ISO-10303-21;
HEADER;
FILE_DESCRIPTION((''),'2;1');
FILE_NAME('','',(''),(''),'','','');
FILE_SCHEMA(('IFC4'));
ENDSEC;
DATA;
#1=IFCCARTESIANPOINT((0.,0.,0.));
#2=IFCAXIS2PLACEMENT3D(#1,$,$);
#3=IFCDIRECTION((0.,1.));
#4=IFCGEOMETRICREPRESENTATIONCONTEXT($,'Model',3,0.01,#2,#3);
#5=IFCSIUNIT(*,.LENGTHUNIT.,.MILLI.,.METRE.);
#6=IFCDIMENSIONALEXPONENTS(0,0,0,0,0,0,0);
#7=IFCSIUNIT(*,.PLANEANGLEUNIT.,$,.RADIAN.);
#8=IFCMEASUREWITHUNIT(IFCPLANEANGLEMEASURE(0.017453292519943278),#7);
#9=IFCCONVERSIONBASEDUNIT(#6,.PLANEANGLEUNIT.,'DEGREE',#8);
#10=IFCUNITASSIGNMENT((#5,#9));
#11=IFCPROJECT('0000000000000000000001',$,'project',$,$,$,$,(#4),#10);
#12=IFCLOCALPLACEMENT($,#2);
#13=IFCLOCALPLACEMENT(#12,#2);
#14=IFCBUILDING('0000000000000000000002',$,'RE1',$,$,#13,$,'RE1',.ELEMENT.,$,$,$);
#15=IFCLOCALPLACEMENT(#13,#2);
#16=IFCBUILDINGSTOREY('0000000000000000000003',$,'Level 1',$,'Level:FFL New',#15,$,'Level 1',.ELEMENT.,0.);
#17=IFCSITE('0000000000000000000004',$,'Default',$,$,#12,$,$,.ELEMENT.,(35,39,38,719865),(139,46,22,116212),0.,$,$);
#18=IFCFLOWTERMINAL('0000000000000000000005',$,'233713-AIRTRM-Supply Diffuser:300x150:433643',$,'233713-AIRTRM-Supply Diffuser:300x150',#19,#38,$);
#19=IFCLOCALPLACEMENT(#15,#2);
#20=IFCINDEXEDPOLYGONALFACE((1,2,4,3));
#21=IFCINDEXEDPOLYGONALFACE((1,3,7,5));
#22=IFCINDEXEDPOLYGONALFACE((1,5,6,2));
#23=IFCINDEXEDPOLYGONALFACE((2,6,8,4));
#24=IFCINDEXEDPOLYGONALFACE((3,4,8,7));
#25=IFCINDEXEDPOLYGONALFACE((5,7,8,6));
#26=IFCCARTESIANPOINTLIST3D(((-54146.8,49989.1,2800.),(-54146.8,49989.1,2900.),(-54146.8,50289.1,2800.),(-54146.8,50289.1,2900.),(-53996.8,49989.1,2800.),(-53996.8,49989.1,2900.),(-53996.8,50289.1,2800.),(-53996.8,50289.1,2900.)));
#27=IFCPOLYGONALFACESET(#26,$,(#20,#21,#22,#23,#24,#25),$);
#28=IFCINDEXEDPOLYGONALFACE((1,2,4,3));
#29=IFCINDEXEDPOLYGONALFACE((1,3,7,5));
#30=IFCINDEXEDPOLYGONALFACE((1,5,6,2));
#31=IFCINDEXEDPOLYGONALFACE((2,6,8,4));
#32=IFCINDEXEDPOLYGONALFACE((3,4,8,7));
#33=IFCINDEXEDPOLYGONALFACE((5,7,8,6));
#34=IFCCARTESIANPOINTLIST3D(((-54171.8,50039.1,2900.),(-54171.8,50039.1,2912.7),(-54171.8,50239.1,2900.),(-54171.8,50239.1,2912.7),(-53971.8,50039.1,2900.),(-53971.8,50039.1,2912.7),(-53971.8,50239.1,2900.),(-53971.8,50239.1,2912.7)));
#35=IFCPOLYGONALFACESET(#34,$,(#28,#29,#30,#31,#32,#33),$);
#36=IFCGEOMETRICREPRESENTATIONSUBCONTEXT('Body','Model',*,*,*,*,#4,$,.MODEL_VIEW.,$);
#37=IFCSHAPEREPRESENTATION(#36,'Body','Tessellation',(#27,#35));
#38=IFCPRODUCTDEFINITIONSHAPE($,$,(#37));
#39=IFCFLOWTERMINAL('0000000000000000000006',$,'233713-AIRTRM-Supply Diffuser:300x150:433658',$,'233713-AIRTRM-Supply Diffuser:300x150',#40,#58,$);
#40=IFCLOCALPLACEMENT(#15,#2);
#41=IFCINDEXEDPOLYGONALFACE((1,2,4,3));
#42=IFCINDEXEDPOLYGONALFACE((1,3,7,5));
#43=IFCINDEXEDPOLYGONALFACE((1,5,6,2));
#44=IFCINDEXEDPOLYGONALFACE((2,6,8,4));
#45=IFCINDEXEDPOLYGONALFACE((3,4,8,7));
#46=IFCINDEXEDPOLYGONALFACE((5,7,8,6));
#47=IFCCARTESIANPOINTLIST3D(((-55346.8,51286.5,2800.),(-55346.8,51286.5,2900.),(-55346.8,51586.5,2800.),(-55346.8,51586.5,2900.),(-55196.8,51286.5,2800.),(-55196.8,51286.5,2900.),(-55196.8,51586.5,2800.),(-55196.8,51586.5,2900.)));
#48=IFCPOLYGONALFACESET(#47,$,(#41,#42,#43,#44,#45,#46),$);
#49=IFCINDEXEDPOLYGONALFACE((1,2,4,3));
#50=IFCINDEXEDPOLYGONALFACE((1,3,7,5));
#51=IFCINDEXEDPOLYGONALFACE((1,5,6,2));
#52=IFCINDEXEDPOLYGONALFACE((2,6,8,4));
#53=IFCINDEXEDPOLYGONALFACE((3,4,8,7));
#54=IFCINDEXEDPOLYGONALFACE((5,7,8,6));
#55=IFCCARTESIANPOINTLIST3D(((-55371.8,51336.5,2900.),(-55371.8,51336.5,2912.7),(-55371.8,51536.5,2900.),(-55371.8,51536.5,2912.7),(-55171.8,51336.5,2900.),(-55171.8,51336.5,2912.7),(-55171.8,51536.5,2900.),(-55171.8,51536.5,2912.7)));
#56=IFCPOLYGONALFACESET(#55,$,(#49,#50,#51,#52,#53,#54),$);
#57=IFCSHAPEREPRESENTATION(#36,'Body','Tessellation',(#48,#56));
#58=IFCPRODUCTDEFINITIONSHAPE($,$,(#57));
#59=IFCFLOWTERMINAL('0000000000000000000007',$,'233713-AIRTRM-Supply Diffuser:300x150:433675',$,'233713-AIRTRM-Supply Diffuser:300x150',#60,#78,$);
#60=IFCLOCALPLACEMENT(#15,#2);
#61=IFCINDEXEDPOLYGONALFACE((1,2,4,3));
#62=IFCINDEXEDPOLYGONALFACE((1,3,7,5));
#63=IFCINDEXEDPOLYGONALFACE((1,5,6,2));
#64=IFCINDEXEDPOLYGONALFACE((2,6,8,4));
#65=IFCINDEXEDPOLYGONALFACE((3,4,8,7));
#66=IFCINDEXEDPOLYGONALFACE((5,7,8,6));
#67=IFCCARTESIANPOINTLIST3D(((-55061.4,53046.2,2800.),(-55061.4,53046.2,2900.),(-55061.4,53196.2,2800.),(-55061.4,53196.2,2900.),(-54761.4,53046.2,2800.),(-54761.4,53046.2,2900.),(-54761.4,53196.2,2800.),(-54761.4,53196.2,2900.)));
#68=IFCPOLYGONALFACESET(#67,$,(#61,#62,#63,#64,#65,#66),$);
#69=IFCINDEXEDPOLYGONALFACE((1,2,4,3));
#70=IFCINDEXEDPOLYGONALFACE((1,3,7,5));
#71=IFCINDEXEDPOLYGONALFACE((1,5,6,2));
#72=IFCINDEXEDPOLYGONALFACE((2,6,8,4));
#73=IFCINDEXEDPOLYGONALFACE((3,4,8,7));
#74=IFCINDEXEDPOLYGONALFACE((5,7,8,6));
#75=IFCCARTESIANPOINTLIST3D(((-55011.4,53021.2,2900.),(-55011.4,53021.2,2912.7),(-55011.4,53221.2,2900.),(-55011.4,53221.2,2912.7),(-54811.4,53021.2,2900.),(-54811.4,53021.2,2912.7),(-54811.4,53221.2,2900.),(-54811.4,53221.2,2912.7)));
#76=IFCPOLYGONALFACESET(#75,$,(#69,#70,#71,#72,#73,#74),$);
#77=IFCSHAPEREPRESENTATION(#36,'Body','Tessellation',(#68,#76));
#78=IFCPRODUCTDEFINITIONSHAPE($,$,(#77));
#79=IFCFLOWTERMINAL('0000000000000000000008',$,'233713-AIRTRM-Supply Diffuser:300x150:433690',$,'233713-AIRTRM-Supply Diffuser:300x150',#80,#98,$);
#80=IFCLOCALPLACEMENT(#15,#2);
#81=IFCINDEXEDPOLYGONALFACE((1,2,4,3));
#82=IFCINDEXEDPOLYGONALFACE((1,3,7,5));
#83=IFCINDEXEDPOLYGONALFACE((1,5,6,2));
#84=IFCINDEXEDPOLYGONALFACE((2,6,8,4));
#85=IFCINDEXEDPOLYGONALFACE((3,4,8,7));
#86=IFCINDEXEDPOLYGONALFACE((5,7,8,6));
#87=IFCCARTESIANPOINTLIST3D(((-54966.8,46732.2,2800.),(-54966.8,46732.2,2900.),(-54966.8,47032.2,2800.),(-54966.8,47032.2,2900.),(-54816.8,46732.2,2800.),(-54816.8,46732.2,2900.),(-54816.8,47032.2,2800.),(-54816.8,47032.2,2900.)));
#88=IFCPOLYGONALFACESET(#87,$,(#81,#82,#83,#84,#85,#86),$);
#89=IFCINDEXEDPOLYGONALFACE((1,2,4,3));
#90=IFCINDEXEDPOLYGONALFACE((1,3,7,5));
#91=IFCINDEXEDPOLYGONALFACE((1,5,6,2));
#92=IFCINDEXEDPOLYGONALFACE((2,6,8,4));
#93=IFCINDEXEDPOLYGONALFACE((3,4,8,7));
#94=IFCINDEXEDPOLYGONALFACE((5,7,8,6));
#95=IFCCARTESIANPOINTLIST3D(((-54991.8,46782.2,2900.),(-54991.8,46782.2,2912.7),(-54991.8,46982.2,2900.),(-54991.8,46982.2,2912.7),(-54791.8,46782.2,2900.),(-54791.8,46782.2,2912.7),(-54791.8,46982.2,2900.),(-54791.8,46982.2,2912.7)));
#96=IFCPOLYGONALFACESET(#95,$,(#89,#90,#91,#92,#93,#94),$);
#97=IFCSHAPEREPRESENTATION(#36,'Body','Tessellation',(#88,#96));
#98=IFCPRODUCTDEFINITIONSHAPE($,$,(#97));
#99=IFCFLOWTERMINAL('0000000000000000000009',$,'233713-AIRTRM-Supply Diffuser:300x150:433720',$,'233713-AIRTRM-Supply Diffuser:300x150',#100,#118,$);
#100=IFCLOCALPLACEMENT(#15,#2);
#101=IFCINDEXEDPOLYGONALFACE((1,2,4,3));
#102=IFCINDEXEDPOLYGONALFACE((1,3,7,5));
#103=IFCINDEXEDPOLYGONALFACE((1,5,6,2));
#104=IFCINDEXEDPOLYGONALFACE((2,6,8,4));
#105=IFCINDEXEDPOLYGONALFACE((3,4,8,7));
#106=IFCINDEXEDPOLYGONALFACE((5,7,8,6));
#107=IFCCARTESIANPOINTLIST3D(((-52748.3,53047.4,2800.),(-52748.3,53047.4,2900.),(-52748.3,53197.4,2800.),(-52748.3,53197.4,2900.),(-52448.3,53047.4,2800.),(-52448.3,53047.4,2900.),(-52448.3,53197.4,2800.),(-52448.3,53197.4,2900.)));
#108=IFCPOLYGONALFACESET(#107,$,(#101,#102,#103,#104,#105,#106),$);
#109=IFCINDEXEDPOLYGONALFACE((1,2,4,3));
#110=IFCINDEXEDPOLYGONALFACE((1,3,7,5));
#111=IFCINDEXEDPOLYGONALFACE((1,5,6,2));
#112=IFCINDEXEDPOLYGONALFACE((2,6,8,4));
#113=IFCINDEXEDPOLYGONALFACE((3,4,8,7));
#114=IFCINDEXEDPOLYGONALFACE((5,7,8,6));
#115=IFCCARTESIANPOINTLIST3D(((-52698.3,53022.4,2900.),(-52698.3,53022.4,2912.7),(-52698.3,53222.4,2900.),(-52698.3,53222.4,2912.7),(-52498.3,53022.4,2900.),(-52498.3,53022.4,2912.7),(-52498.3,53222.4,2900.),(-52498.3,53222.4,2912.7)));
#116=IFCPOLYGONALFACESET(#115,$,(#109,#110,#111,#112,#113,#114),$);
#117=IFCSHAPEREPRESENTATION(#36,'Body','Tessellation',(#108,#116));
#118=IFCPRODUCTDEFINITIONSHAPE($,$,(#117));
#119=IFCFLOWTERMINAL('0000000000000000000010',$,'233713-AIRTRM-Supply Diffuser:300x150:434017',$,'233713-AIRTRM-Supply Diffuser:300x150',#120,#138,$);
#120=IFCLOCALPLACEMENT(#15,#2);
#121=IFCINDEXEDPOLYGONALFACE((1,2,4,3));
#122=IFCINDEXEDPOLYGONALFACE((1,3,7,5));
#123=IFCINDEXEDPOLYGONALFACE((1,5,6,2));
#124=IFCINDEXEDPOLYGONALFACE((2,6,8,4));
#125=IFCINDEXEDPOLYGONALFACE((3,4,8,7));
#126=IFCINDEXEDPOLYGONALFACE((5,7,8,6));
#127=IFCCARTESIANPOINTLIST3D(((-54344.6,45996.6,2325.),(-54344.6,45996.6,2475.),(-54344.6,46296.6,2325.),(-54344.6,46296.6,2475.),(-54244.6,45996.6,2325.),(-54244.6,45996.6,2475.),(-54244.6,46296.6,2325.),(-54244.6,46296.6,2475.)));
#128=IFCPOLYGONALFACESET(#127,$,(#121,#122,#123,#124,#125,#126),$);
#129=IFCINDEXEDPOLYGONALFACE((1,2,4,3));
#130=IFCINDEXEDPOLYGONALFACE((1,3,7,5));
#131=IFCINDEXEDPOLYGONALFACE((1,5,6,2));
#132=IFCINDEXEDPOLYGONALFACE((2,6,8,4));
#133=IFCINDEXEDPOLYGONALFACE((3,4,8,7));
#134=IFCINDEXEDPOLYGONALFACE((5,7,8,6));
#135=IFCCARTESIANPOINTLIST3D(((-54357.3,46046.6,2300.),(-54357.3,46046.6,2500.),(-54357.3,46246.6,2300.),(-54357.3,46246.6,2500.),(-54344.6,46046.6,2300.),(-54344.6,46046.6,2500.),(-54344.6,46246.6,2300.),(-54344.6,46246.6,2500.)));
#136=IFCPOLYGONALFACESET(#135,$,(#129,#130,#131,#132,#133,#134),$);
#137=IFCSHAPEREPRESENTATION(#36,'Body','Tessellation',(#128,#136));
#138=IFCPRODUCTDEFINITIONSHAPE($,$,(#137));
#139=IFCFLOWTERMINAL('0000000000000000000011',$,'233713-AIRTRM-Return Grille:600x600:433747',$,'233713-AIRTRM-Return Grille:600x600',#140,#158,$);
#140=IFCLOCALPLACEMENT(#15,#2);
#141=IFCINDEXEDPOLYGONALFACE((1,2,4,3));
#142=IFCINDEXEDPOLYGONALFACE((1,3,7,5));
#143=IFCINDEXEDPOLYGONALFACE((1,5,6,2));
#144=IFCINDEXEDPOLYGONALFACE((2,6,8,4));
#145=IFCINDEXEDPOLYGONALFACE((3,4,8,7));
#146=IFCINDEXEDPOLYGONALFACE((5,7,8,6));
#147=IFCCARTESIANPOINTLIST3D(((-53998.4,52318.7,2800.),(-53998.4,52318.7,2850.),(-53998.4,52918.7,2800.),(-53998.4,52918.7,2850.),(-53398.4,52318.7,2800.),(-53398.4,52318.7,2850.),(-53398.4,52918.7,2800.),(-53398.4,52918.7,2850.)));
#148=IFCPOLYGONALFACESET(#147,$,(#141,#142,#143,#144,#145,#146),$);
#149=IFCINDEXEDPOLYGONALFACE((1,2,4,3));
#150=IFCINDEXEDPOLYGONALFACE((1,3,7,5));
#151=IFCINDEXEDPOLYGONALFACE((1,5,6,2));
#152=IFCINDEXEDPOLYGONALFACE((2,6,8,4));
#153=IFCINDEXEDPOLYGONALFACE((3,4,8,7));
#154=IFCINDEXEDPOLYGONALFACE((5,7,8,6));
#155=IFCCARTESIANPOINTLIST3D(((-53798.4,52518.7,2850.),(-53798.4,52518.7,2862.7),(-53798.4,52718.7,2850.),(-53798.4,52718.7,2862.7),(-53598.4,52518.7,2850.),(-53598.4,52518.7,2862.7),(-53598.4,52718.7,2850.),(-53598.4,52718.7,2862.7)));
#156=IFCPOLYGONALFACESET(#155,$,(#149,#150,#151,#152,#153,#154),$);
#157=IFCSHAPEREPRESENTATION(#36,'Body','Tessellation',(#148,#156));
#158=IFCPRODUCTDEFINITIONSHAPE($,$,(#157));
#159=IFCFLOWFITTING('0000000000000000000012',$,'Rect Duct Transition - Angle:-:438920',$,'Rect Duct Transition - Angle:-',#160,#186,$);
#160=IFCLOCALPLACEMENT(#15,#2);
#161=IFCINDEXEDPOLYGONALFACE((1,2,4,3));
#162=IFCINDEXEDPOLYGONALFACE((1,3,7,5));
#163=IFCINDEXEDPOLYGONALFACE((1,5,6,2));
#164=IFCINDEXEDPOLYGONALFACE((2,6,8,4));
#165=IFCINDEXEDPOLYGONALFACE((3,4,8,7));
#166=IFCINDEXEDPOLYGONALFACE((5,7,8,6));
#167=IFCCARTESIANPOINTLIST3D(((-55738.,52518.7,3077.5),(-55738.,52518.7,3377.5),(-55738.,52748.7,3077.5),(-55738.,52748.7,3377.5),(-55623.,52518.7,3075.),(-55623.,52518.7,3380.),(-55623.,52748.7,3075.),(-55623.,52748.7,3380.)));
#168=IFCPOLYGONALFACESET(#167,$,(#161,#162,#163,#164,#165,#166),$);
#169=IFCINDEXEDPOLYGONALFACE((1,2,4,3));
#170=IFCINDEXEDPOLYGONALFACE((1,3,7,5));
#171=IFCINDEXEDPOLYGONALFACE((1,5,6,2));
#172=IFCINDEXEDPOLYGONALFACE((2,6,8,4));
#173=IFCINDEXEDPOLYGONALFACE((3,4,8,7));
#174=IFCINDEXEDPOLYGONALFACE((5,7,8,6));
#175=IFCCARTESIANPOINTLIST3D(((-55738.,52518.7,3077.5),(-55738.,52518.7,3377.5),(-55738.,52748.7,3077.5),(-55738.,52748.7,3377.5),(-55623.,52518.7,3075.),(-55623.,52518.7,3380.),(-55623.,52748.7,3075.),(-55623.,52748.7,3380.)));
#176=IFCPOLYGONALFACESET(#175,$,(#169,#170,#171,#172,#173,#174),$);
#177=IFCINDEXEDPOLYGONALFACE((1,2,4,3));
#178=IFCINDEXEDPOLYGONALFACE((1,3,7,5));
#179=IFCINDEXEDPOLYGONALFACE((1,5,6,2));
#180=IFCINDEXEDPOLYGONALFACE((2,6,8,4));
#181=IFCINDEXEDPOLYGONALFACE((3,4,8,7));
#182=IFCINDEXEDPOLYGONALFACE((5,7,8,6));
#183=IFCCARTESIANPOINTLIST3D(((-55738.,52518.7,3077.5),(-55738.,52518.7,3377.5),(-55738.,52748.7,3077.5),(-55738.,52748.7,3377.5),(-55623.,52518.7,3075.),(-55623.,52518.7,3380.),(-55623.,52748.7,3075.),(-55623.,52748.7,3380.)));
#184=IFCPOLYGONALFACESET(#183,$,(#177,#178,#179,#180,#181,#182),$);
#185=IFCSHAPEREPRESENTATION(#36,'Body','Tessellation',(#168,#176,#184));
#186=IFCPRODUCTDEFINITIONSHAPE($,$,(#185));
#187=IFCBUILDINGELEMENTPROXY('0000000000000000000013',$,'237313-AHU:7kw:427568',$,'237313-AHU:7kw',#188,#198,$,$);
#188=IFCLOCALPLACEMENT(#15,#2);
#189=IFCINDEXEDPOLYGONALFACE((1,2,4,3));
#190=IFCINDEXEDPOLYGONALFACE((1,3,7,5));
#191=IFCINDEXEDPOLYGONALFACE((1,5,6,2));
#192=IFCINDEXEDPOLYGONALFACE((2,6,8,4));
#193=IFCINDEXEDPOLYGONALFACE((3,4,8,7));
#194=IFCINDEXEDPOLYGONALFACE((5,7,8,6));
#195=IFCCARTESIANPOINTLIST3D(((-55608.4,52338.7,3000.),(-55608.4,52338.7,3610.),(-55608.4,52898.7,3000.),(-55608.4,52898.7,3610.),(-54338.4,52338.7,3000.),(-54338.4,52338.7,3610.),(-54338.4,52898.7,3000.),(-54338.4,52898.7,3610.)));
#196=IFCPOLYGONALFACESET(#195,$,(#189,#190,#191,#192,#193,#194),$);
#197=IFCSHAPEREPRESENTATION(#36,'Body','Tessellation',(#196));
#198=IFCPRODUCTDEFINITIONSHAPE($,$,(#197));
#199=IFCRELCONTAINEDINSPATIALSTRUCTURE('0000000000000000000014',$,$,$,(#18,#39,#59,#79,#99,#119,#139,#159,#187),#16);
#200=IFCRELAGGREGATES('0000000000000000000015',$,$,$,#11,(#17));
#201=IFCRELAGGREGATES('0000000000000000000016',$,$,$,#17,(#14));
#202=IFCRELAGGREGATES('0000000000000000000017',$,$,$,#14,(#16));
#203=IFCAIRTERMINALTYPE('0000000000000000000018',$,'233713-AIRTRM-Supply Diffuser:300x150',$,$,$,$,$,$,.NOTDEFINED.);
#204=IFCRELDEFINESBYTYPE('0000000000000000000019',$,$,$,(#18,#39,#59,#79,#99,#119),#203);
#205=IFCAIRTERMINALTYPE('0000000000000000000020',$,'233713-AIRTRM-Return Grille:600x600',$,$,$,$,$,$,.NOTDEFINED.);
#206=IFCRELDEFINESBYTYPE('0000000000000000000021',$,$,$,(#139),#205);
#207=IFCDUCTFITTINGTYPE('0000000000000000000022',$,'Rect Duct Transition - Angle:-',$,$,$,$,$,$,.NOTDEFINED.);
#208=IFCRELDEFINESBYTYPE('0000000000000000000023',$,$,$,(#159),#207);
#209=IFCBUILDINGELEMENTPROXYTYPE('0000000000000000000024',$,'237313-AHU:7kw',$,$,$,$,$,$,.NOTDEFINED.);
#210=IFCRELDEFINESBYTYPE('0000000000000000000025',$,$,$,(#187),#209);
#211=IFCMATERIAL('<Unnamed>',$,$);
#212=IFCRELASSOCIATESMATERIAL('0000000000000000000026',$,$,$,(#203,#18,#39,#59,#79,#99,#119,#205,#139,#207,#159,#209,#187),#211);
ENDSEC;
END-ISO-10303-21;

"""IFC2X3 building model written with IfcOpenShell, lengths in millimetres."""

from ifc_helpers import new_model, entity, si_unit, converted_unit, direction, frame, frame_2d, origin, origin_2d_with_axis, place, context, subcontext, project, spatial, polyline, rectangle, outline, extrude, source, transform, mapped, material, type_object, type_shapes, element, save


model = new_model("IFC2X3")

# Units and contexts
model_context = context("Model", 3, precision=0.01, world=origin(), true_north=direction((0.0, 1.0)))
body_context = subcontext(model_context, "Body", "Model", "MODEL_VIEW")
ifc_project = project(units=[si_unit("LENGTHUNIT", "METRE", prefix="MILLI"), converted_unit("PLANEANGLEUNIT", "DEGREE", entity("IfcPlaneAngleMeasure", 0.017453292519943278), si_unit("PLANEANGLEUNIT", "RADIAN"), dimensions=[0, 0, 0, 0, 0, 0, 0])], contexts=[model_context])

# Site, building, storey
site_placement = place(None, origin())
site = spatial("IfcSite", under=ifc_project, at=site_placement, Name="Default", CompositionType="ELEMENT", RefLatitude=(35, 39, 38, 719865), RefLongitude=(139, 46, 22, 116212), RefElevation=0.0)
building_placement = place(site_placement, origin())
building = spatial("IfcBuilding", under=site, at=building_placement, Name="RE1", LongName="RE1", CompositionType="ELEMENT")
storey_placement = place(building_placement, origin())
storey = spatial("IfcBuildingStorey", under=building, at=storey_placement, Name="Level 1", ObjectType="Level:FFL New", LongName="Level 1", CompositionType="ELEMENT", Elevation=0.0)

# Flow terminals
ifc_material = material(Name="<Unnamed>")
air_terminal_type_1 = type_object("IfcAirTerminalType", Name="233713-AIRTRM-Supply Diffuser:300x150", PredefinedType="NOTDEFINED", material=ifc_material)
shared_shape_1 = source(origin(), body_context, "Body", "SweptSolid", [
    extrude(rectangle(XDim=300.0, YDim=150.0, at=origin_2d_with_axis()), frame((0.0, 0.0, -100.0), z_axis=(0.0, 0.0, 1.0), x_axis=(-1.0, 0.0, 0.0)), (0.0, 0.0, 1.0), 100.0),
    extrude(rectangle(XDim=200.0, YDim=200.0, at=frame_2d((0.0, 0.0), x_axis=(1.0, 0.0))), frame((0.0, 0.0, -112.7), z_axis=(0.0, 0.0, 1.0), x_axis=(-1.0, 0.0, 0.0)), (0.0, 0.0, 1.0), 12.7),
])
type_shapes(air_terminal_type_1, [shared_shape_1])
for number, where, z_axis, x_axis, name in (
    (1, (-54071.8, 50139.1, 2800.0), (0.0, 0.0, -1.0), (0.0, 1.0, 0.0), "233713-AIRTRM-Supply Diffuser:300x150:433643"),
    (2, (-55271.8, 51436.5, 2800.0), (0.0, 0.0, -1.0), (0.0, 1.0, 0.0), "233713-AIRTRM-Supply Diffuser:300x150:433658"),
    (3, (-54911.4, 53121.2, 2800.0), (0.0, 0.0, -1.0), (-1.0, 0.0, 0.0), "233713-AIRTRM-Supply Diffuser:300x150:433675"),
    (4, (-54891.8, 46882.2, 2800.0), (0.0, 0.0, -1.0), (0.0, 1.0, 0.0), "233713-AIRTRM-Supply Diffuser:300x150:433690"),
    (5, (-52598.3, 53122.4, 2800.0), (0.0, 0.0, -1.0), (1.0, 0.0, 0.0), "233713-AIRTRM-Supply Diffuser:300x150:433720"),
    (6, (-54244.6, 46146.6, 2400.0), (1.0, 0.0, 0.0), (0.0, 1.0, 0.0), "233713-AIRTRM-Supply Diffuser:300x150:434017"),
):
    element("IfcFlowTerminal", number, at=place(storey_placement, frame(where, z_axis=z_axis, x_axis=x_axis)), inside=storey, type_object=air_terminal_type_1, material=ifc_material, Name=name, ObjectType="233713-AIRTRM-Supply Diffuser:300x150", context=body_context, shape_type="MappedRepresentation", body=[
        mapped(shared_shape_1, transform((0.0, 0.0, 0.0), scale=1.0)),
    ])
air_terminal_type_2 = type_object("IfcAirTerminalType", Name="233713-AIRTRM-Return Grille:600x600", PredefinedType="NOTDEFINED", material=ifc_material)
shared_shape_2 = source(origin(), body_context, "Body", "SweptSolid", [
    extrude(rectangle(XDim=600.0, YDim=600.0, at=frame_2d((0.0, 0.0), x_axis=(1.0, 0.0))), frame((0.0, 0.0, -50.0), z_axis=(0.0, 0.0, 1.0), x_axis=(-1.0, 0.0, 0.0)), (0.0, 0.0, 1.0), 50.0),
    extrude(rectangle(XDim=200.0, YDim=200.0, at=frame_2d((0.0, 0.0), x_axis=(1.0, 0.0))), frame((0.0, 0.0, -62.7), z_axis=(0.0, 0.0, 1.0), x_axis=(-1.0, 0.0, 0.0)), (0.0, 0.0, 1.0), 12.7),
])
type_shapes(air_terminal_type_2, [shared_shape_2])
flow_terminal_placement = place(storey_placement, frame((-53698.4, 52618.7, 2800.0), z_axis=(0.0, 0.0, -1.0), x_axis=(0.0, 1.0, 0.0)))
element("IfcFlowTerminal", 7, at=flow_terminal_placement, inside=storey, type_object=air_terminal_type_2, material=ifc_material, Name="233713-AIRTRM-Return Grille:600x600:433747", ObjectType="233713-AIRTRM-Return Grille:600x600", context=body_context, shape_type="MappedRepresentation", body=[
    mapped(shared_shape_2, transform((0.0, 0.0, 0.0), scale=1.0)),
])

# Flow fitting
duct_fitting_type_1 = type_object("IfcDuctFittingType", Name="Rect Duct Transition - Angle:-", PredefinedType="NOTDEFINED", material=ifc_material)
shared_shape_3 = source(origin(), body_context, "Body", "SweptSolid", [
    extrude(outline(polyline([(-54.2, -151.2), (60.8, -151.2), (54.2, 153.7), (-60.7, 148.7), (-54.2, -151.2)])), frame((57.5, -115.0, 0.0), z_axis=(0.0, 1.0, 0.0), x_axis=(0.999764, 0.0, 0.021734)), (0.0, 0.0, 1.0), 230.0),
    extrude(outline(polyline([(-54.2, -151.2), (60.8, -151.2), (54.2, 153.7), (-60.7, 148.7), (-54.2, -151.2)])), frame((57.5, -115.0, 0.0), z_axis=(0.0, 1.0, 0.0), x_axis=(0.999764, 0.0, 0.021734)), (0.0, 0.0, 1.0), 230.0),
    extrude(outline(polyline([(-54.2, -151.2), (60.8, -151.2), (54.2, 153.7), (-60.7, 148.7), (-54.2, -151.2)])), frame((57.5, -115.0, 0.0), z_axis=(0.0, 1.0, 0.0), x_axis=(0.999764, 0.0, 0.021734)), (0.0, 0.0, 1.0), 230.0),
])
type_shapes(duct_fitting_type_1, [shared_shape_3])
flow_fitting_1_placement = place(storey_placement, frame((-55738.0, 52633.7, 3227.5)))
element("IfcFlowFitting", 8, at=flow_fitting_1_placement, inside=storey, type_object=duct_fitting_type_1, material=ifc_material, Name="Rect Duct Transition - Angle:-:438920", ObjectType="Rect Duct Transition - Angle:-", context=body_context, shape_type="MappedRepresentation", body=[
    mapped(shared_shape_3, transform((0.0, 0.0, 0.0), scale=1.0)),
])

# Building element proxy
building_element_proxy_type = type_object("IfcBuildingElementProxyType", Name="237313-AHU:7kw", PredefinedType="NOTDEFINED", material=ifc_material)
shared_shape_4 = source(origin(), body_context, "Body", "SweptSolid", [
    extrude(rectangle(XDim=1270.0, YDim=560.0, at=frame_2d((0.0, 0.0), x_axis=(1.0, 0.0))), frame((0.0, 0.0, 0.0), z_axis=(0.0, 0.0, 1.0), x_axis=(-1.0, 0.0, 0.0)), (0.0, 0.0, 1.0), 610.0),
])
type_shapes(building_element_proxy_type, [shared_shape_4])
proxy_placement = place(storey_placement, frame((-54973.4, 52618.7, 3000.0), z_axis=(0.0, 0.0, 1.0), x_axis=(-1.0, 0.0, 0.0)))
element("IfcBuildingElementProxy", 9, at=proxy_placement, inside=storey, type_object=building_element_proxy_type, material=ifc_material, Name="237313-AHU:7kw:427568", ObjectType="237313-AHU:7kw", context=body_context, shape_type="MappedRepresentation", body=[
    mapped(shared_shape_4, transform((0.0, 0.0, 0.0), scale=1.0)),
])

save(model, "model.ifc")
